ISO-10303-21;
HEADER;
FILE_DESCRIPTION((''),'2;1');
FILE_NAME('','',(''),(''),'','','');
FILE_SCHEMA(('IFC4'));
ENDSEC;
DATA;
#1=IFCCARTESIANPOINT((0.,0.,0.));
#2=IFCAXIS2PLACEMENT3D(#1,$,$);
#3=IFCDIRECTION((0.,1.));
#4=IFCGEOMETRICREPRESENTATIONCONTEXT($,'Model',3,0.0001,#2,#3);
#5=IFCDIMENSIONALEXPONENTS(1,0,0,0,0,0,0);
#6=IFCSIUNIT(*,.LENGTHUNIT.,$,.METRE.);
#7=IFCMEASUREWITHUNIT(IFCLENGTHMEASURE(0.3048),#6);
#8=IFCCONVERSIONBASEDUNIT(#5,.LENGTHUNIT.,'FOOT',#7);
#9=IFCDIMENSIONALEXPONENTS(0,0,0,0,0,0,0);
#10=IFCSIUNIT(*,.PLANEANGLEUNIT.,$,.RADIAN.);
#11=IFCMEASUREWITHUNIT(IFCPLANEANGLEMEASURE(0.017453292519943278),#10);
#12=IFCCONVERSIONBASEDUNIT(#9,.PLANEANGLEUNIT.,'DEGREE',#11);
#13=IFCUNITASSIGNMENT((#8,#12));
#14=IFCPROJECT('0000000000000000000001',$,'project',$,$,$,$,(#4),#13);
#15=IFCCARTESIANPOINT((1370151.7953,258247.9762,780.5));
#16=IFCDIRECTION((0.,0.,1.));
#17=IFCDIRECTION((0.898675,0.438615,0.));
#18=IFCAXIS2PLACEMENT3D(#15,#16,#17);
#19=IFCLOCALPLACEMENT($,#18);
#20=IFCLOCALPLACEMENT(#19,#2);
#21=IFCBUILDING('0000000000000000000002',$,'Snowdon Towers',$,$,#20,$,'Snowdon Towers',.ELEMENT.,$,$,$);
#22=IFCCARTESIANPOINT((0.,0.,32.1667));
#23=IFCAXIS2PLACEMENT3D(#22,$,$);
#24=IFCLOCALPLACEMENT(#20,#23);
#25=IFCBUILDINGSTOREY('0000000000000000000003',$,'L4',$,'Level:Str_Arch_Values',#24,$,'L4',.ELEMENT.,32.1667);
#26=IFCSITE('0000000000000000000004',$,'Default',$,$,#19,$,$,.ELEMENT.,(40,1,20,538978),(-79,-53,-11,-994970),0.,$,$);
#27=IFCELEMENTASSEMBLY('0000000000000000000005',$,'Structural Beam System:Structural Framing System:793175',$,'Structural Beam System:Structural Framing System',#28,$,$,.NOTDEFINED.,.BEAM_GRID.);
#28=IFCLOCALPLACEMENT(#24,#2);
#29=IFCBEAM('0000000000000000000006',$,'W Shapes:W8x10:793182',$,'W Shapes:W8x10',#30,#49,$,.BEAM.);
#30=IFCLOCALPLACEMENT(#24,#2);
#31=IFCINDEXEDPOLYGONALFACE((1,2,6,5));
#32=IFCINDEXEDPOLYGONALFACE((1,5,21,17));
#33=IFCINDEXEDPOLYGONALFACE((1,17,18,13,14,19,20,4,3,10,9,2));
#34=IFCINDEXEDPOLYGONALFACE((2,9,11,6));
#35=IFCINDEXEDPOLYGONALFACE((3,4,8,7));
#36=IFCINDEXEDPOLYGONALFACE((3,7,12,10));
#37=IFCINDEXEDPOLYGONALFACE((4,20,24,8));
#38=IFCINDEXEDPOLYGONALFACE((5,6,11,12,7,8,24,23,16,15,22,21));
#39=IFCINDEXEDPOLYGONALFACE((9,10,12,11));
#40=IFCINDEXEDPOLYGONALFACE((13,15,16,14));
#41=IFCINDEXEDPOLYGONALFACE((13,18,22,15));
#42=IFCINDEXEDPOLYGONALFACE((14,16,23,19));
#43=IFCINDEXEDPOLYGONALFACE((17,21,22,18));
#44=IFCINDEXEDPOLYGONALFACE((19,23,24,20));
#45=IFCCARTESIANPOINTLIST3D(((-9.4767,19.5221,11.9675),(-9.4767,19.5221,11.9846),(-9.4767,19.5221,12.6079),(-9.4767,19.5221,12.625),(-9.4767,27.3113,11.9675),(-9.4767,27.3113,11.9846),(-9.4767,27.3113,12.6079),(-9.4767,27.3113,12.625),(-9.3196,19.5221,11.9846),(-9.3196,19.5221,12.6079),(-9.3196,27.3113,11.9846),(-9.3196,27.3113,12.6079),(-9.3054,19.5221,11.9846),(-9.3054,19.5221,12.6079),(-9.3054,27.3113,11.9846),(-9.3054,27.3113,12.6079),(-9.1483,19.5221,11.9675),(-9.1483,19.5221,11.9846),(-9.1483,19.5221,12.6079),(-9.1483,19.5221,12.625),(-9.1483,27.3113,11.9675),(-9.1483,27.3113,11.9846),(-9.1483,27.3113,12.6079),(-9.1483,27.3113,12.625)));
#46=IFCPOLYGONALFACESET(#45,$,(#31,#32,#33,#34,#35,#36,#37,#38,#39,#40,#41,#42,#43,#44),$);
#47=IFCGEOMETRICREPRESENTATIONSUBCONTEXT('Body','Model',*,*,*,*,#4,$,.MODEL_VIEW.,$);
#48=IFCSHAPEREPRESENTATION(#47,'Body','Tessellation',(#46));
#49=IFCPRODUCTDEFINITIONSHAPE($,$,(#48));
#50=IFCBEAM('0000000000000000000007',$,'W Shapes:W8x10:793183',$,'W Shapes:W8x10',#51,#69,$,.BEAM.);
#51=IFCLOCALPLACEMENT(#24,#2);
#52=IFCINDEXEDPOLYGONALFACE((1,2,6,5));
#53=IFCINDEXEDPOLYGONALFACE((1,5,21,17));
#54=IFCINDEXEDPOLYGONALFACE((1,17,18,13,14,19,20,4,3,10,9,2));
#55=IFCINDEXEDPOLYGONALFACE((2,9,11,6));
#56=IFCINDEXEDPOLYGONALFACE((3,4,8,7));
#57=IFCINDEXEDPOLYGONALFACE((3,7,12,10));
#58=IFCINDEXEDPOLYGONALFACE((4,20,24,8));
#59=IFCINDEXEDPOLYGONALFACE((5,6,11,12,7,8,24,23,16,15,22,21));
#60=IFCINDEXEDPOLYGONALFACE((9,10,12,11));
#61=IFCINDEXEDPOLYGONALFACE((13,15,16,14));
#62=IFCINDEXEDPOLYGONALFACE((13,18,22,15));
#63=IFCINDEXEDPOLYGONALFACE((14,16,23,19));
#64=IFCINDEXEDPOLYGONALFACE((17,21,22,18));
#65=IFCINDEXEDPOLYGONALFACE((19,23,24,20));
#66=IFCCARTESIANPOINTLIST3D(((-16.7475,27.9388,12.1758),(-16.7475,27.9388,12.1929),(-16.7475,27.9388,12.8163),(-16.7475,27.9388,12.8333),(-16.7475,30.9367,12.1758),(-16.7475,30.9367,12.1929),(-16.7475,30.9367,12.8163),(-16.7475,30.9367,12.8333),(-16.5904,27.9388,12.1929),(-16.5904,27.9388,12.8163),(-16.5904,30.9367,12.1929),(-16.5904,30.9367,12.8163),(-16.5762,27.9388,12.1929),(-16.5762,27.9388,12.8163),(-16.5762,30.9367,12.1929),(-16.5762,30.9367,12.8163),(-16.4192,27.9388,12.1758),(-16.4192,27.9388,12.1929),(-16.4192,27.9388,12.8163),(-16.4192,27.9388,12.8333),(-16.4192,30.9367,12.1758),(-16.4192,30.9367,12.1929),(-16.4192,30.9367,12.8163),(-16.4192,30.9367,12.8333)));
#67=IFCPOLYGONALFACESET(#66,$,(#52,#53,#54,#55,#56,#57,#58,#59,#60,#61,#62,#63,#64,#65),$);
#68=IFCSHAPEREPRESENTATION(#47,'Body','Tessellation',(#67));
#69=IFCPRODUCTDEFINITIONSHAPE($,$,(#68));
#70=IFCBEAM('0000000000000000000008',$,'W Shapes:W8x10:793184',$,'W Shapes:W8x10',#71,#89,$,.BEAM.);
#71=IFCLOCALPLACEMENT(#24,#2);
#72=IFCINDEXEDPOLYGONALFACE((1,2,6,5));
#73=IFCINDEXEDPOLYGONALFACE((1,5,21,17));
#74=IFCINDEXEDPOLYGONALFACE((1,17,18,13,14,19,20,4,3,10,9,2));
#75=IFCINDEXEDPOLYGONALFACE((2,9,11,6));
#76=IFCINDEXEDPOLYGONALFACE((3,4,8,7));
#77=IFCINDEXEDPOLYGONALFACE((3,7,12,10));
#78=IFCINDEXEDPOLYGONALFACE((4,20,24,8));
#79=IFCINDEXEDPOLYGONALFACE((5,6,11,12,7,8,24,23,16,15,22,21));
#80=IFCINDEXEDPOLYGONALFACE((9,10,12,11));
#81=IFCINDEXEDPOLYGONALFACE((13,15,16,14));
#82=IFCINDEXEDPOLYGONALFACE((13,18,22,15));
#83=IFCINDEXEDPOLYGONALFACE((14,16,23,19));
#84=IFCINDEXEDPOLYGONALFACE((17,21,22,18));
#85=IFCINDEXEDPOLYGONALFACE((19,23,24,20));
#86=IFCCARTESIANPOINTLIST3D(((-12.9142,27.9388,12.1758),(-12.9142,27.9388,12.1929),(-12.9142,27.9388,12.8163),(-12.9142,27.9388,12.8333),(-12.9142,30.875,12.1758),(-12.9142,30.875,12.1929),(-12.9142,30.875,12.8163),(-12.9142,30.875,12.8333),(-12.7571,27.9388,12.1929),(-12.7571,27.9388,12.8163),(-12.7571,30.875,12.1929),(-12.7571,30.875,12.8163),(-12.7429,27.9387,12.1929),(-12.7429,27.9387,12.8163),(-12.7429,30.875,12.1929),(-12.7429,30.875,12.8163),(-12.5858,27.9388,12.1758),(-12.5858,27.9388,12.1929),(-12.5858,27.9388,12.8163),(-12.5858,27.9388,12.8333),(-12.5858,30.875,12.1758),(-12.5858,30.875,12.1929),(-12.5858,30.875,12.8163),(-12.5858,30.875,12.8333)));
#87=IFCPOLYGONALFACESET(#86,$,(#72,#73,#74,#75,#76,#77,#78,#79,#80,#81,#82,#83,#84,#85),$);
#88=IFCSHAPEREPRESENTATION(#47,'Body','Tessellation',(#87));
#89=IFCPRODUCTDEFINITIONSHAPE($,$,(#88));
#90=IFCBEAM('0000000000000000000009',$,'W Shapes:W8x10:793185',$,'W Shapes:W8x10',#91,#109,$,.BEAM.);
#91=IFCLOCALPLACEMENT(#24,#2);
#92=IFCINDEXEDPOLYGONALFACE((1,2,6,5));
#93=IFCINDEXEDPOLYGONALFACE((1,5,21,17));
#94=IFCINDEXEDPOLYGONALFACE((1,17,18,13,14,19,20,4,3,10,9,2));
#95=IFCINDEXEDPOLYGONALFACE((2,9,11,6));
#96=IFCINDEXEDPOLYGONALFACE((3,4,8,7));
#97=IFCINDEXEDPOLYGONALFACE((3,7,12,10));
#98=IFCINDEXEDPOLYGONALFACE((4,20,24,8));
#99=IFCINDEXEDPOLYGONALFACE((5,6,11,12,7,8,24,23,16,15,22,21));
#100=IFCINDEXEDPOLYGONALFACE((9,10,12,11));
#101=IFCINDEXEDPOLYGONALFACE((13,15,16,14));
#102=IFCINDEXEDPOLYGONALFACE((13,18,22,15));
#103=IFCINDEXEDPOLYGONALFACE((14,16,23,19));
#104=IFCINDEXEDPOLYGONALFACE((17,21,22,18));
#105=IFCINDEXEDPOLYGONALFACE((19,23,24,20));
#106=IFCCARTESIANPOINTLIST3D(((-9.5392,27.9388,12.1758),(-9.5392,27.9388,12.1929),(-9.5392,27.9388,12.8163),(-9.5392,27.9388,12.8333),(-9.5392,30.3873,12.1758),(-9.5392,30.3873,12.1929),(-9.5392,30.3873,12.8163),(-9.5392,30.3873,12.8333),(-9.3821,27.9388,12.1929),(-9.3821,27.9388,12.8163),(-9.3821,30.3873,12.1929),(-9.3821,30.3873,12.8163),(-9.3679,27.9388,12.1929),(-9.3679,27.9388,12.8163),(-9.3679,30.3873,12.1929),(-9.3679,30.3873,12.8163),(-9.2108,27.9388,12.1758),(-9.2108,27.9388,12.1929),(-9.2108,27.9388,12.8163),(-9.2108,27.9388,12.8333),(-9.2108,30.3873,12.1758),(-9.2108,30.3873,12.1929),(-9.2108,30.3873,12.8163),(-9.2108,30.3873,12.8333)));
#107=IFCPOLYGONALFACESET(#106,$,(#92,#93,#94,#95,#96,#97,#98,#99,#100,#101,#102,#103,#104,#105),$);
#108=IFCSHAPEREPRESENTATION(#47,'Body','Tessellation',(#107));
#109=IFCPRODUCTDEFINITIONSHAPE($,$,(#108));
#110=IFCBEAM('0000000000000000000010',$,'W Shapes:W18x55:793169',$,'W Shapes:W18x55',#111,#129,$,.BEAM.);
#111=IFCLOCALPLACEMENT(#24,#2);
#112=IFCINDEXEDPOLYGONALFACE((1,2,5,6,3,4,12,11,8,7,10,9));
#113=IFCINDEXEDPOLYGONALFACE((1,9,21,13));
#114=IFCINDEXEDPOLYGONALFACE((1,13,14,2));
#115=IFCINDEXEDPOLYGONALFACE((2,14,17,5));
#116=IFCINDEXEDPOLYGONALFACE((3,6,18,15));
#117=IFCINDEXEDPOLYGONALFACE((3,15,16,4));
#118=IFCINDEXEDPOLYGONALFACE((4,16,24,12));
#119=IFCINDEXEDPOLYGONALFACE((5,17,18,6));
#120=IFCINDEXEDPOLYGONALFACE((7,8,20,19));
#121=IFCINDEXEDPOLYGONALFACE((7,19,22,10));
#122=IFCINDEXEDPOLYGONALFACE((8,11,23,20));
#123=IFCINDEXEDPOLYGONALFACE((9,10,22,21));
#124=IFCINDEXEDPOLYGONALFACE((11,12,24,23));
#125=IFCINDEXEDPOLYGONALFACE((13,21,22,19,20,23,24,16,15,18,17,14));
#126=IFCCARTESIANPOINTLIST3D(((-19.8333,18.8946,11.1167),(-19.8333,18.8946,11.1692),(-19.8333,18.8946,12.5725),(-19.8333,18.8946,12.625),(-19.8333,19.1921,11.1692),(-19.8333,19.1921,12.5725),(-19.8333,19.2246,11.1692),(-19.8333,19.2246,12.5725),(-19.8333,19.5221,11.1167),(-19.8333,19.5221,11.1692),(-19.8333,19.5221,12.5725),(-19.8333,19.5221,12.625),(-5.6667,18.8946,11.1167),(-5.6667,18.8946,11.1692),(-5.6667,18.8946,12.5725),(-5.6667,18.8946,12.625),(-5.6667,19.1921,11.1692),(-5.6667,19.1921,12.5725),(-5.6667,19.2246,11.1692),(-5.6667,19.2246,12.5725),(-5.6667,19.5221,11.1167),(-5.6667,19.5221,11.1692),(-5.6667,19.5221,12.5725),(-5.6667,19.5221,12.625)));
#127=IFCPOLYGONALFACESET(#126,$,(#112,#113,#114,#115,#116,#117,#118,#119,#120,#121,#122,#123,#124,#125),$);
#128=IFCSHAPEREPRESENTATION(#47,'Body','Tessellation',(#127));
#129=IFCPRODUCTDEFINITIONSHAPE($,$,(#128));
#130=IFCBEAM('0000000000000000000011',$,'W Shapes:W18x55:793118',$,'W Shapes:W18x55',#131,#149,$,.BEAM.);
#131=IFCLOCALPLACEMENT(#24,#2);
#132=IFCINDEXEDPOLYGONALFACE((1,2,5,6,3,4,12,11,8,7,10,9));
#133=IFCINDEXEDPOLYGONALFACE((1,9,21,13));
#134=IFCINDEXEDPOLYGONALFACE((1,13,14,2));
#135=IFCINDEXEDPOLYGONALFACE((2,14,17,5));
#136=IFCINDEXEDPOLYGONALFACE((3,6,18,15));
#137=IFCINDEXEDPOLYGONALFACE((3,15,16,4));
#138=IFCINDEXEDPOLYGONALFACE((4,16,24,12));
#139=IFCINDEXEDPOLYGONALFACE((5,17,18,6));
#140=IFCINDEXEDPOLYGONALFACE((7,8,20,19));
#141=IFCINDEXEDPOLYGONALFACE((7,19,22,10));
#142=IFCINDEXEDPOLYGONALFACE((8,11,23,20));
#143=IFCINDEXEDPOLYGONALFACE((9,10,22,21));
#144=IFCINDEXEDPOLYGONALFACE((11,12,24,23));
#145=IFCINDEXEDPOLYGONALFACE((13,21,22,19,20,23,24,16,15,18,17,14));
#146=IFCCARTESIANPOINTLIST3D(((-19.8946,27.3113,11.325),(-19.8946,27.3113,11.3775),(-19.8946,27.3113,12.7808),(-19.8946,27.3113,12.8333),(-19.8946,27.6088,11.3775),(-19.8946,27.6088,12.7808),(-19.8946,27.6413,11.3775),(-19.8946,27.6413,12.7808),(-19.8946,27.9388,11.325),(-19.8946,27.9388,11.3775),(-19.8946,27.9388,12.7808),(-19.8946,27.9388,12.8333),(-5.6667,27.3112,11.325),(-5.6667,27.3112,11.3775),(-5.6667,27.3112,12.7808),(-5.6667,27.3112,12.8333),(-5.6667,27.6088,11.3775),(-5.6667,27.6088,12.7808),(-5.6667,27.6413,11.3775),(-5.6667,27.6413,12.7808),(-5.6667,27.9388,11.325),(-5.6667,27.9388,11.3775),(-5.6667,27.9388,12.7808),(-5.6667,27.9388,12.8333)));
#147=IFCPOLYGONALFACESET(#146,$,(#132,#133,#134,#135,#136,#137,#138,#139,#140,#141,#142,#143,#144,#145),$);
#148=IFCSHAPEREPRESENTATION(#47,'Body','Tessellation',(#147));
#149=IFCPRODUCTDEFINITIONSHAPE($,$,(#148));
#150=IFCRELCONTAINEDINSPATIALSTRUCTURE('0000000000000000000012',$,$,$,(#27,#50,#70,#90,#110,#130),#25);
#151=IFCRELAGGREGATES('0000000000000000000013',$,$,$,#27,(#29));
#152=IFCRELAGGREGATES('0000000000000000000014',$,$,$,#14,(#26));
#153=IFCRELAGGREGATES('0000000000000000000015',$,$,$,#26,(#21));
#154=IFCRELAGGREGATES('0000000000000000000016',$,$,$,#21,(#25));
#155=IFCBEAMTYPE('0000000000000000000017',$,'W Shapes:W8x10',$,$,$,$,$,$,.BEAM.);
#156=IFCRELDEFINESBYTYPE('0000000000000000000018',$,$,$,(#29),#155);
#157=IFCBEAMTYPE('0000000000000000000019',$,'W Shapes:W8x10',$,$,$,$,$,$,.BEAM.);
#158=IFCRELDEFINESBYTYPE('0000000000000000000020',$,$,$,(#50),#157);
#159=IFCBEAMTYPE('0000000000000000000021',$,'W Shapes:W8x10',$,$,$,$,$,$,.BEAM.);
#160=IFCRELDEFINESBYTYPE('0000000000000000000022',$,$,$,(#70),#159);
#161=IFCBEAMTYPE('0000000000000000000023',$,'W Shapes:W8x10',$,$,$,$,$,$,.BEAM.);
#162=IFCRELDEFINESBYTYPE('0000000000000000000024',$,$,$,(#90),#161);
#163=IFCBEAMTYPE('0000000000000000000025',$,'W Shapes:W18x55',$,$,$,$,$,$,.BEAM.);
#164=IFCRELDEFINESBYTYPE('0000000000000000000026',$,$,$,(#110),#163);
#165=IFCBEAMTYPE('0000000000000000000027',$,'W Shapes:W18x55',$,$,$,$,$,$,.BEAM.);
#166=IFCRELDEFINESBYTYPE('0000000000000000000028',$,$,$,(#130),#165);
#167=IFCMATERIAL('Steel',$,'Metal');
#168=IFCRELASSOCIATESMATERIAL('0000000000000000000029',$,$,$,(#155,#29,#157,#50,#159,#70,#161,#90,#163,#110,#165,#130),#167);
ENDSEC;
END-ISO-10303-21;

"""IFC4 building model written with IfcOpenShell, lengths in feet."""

from ifc_helpers import new_model, entity, si_unit, converted_unit, direction, frame, origin, place, context, subcontext, project, spatial, indexed_curve, outline, extrude, source, transform, mapped, material, type_object, type_shapes, element, aggregate, save


model = new_model("IFC4")

# Units and contexts
model_context = context("Model", 3, precision=0.0001, world=origin(), true_north=direction((0.0, 1.0)))
body_context = subcontext(model_context, "Body", "Model", "MODEL_VIEW")
ifc_project = project(units=[converted_unit("LENGTHUNIT", "FOOT", entity("IfcLengthMeasure", 0.3048), si_unit("LENGTHUNIT", "METRE"), dimensions=[1, 0, 0, 0, 0, 0, 0]), converted_unit("PLANEANGLEUNIT", "DEGREE", entity("IfcPlaneAngleMeasure", 0.017453292519943278), si_unit("PLANEANGLEUNIT", "RADIAN"), dimensions=[0, 0, 0, 0, 0, 0, 0])], contexts=[model_context])

# Site, building, storey
site_placement = place(None, frame((1370151.7953, 258247.9762, 780.5), z_axis=(0.0, 0.0, 1.0), x_axis=(0.898675, 0.438615, 0.0)))
site = spatial("IfcSite", under=ifc_project, at=site_placement, Name="Default", CompositionType="ELEMENT", RefLatitude=(40, 1, 20, 538978), RefLongitude=(-79, -53, -11, -994970), RefElevation=0.0)
building_placement = place(site_placement, origin())
building = spatial("IfcBuilding", under=site, at=building_placement, Name="Snowdon Towers", LongName="Snowdon Towers", CompositionType="ELEMENT")
storey_placement = place(building_placement, frame((0.0, 0.0, 32.1667)))
storey = spatial("IfcBuildingStorey", under=building, at=storey_placement, Name="L4", ObjectType="Level:Str_Arch_Values", LongName="L4", CompositionType="ELEMENT", Elevation=32.1667)

# Shared definitions
ifc_material = material(Name="Steel", Category="Metal")

# Element assembly, beam
assembly_1_placement = place(storey_placement, origin())
assembly_1 = element("IfcElementAssembly", 1, at=assembly_1_placement, inside=storey, Name="Structural Beam System:Structural Framing System:793175", ObjectType="Structural Beam System:Structural Framing System", AssemblyPlace="NOTDEFINED", PredefinedType="BEAM_GRID")
beam_type_1 = type_object("IfcBeamType", Name="W Shapes:W8x10", PredefinedType="BEAM", material=ifc_material)
shared_shape_1 = source(origin(), body_context, "Body", "SweptSolid", [
    extrude(outline(indexed_curve([(-0.1642, -0.3117), (-0.1642, -0.3288), (0.1642, -0.3288), (0.1642, -0.3117), (0.0071, -0.3117), (0.0071, 0.3117), (0.1642, 0.3117), (0.1642, 0.3287), (-0.1642, 0.3287), (-0.1642, 0.3117), (-0.0071, 0.3117), (-0.0071, -0.3117), (-0.1642, -0.3117)], self_intersect=False)), frame((-3.8946, 0.0, 0.0), z_axis=(-1.0, 0.0, 0.0), x_axis=(0.0, -1.0, 0.0)), (0.0, 0.0, -1.0), 7.7892),
])
type_shapes(beam_type_1, [shared_shape_1])
beam_1_placement = place(assembly_1_placement, frame((-9.3125, 23.4167, 12.2963), z_axis=(0.0, 0.0, 1.0), x_axis=(0.0, 1.0, 0.0)))
beam_1 = element("IfcBeam", 2, at=beam_1_placement, type_object=beam_type_1, material=ifc_material, Name="W Shapes:W8x10:793182", ObjectType="W Shapes:W8x10", PredefinedType="BEAM", context=body_context, shape_type="MappedRepresentation", body=[
    mapped(shared_shape_1, transform((0.0, 0.0, 0.0), scale=1.0)),
])
aggregate(assembly_1, [beam_1])

# Beams
beam_type_2 = type_object("IfcBeamType", Name="W Shapes:W8x10", PredefinedType="BEAM", material=ifc_material)
shared_shape_2 = source(origin(), body_context, "Body", "SweptSolid", [
    extrude(outline(indexed_curve([(-0.1642, -0.3117), (-0.1642, -0.3288), (0.1642, -0.3288), (0.1642, -0.3117), (0.0071, -0.3117), (0.0071, 0.3117), (0.1642, 0.3117), (0.1642, 0.3287), (-0.1642, 0.3287), (-0.1642, 0.3117), (-0.0071, 0.3117), (-0.0071, -0.3117), (-0.1642, -0.3117)], self_intersect=False)), frame((-1.3421, 0.0, 0.0), z_axis=(-1.0, 0.0, 0.0), x_axis=(0.0, -1.0, 0.0)), (0.0, 0.0, -1.0), 2.9979),
])
type_shapes(beam_type_2, [shared_shape_2])
beam_2_placement = place(storey_placement, frame((-16.5833, 29.2808, 12.5046), z_axis=(0.0, 0.0, 1.0), x_axis=(0.0, 1.0, 0.0)))
element("IfcBeam", 3, at=beam_2_placement, inside=storey, type_object=beam_type_2, material=ifc_material, Name="W Shapes:W8x10:793183", ObjectType="W Shapes:W8x10", PredefinedType="BEAM", context=body_context, shape_type="MappedRepresentation", body=[
    mapped(shared_shape_2, transform((0.0, 0.0, 0.0), scale=1.0)),
])
beam_type_3 = type_object("IfcBeamType", Name="W Shapes:W8x10", PredefinedType="BEAM", material=ifc_material)
shared_shape_3 = source(origin(), body_context, "Body", "SweptSolid", [
    extrude(outline(indexed_curve([(-0.1642, -0.3117), (-0.1642, -0.3288), (0.1642, -0.3288), (0.1642, -0.3117), (0.0071, -0.3117), (0.0071, 0.3117), (0.1642, 0.3117), (0.1642, 0.3287), (-0.1642, 0.3287), (-0.1642, 0.3117), (-0.0071, 0.3117), (-0.0071, -0.3117), (-0.1642, -0.3117)], self_intersect=False)), frame((-1.3113, 0.0, 0.0), z_axis=(-1.0, 0.0, 0.0), x_axis=(0.0, -1.0, 0.0)), (0.0, 0.0, -1.0), 2.9363),
])
type_shapes(beam_type_3, [shared_shape_3])
beam_3_placement = place(storey_placement, frame((-12.75, 29.25, 12.5046), z_axis=(0.0, 0.0, 1.0), x_axis=(0.0, 1.0, 0.0)))
element("IfcBeam", 4, at=beam_3_placement, inside=storey, type_object=beam_type_3, material=ifc_material, Name="W Shapes:W8x10:793184", ObjectType="W Shapes:W8x10", PredefinedType="BEAM", context=body_context, shape_type="MappedRepresentation", body=[
    mapped(shared_shape_3, transform((0.0, 0.0, 0.0), scale=1.0)),
])
beam_type_4 = type_object("IfcBeamType", Name="W Shapes:W8x10", PredefinedType="BEAM", material=ifc_material)
shared_shape_4 = source(origin(), body_context, "Body", "SweptSolid", [
    extrude(outline(indexed_curve([(-0.1642, -0.3117), (-0.1642, -0.3288), (0.1642, -0.3288), (0.1642, -0.3117), (0.0071, -0.3117), (0.0071, 0.3117), (0.1642, 0.3117), (0.1642, 0.3287), (-0.1642, 0.3287), (-0.1642, 0.3117), (-0.0071, 0.3117), (-0.0071, -0.3117), (-0.1642, -0.3117)], self_intersect=False)), frame((-1.1834, 0.0, 0.0), z_axis=(-1.0, 0.0, 0.0), x_axis=(0.0, -1.0, 0.0)), (0.0, 0.0, -1.0), 2.4485),
])
type_shapes(beam_type_4, [shared_shape_4])
beam_4_placement = place(storey_placement, frame((-9.375, 29.1222, 12.5046), z_axis=(0.0, 0.0, 1.0), x_axis=(0.0, 1.0, 0.0)))
element("IfcBeam", 5, at=beam_4_placement, inside=storey, type_object=beam_type_4, material=ifc_material, Name="W Shapes:W8x10:793185", ObjectType="W Shapes:W8x10", PredefinedType="BEAM", context=body_context, shape_type="MappedRepresentation", body=[
    mapped(shared_shape_4, transform((0.0, 0.0, 0.0), scale=1.0)),
])
beam_type_5 = type_object("IfcBeamType", Name="W Shapes:W18x55", PredefinedType="BEAM", material=ifc_material)
shared_shape_5 = source(origin(), body_context, "Body", "SweptSolid", [
    extrude(outline(indexed_curve([(-0.3138, -0.7017), (-0.3138, -0.7542), (0.3138, -0.7542), (0.3138, -0.7017), (0.0162, -0.7017), (0.0162, 0.7017), (0.3138, 0.7017), (0.3138, 0.7542), (-0.3137, 0.7542), (-0.3137, 0.7017), (-0.0163, 0.7017), (-0.0163, -0.7017), (-0.3138, -0.7017)], self_intersect=False)), frame((-7.2917, 0.0, 0.0), z_axis=(-1.0, 0.0, 0.0), x_axis=(0.0, -1.0, 0.0)), (0.0, 0.0, -1.0), 14.1667),
])
type_shapes(beam_type_5, [shared_shape_5])
beam_5_placement = place(storey_placement, frame((-12.9583, 19.2083, 11.8708), z_axis=(0.0, 0.0, 1.0), x_axis=(-1.0, 0.0, 0.0)))
element("IfcBeam", 6, at=beam_5_placement, inside=storey, type_object=beam_type_5, material=ifc_material, Name="W Shapes:W18x55:793169", ObjectType="W Shapes:W18x55", PredefinedType="BEAM", context=body_context, shape_type="MappedRepresentation", body=[
    mapped(shared_shape_5, transform((0.0, 0.0, 0.0), scale=1.0)),
])

# Beam
beam_type_6 = type_object("IfcBeamType", Name="W Shapes:W18x55", PredefinedType="BEAM", material=ifc_material)
shared_shape_6 = source(origin(), body_context, "Body", "SweptSolid", [
    extrude(outline(indexed_curve([(-0.3138, -0.7017), (-0.3138, -0.7542), (0.3138, -0.7542), (0.3138, -0.7017), (0.0162, -0.7017), (0.0162, 0.7017), (0.3138, 0.7017), (0.3138, 0.7542), (-0.3137, 0.7542), (-0.3137, 0.7017), (-0.0163, 0.7017), (-0.0163, -0.7017), (-0.3138, -0.7017)], self_intersect=False)), frame((-7.2917, 0.0, 0.0), z_axis=(-1.0, 0.0, 0.0), x_axis=(0.0, -1.0, 0.0)), (0.0, 0.0, -1.0), 14.2279),
])
type_shapes(beam_type_6, [shared_shape_6])
beam_6_placement = place(storey_placement, frame((-12.9583, 27.625, 12.0792), z_axis=(0.0, 0.0, 1.0), x_axis=(-1.0, 0.0, 0.0)))
element("IfcBeam", 7, at=beam_6_placement, inside=storey, type_object=beam_type_6, material=ifc_material, Name="W Shapes:W18x55:793118", ObjectType="W Shapes:W18x55", PredefinedType="BEAM", context=body_context, shape_type="MappedRepresentation", body=[
    mapped(shared_shape_6, transform((0.0, 0.0, 0.0), scale=1.0)),
])

save(model, "model.ifc")
